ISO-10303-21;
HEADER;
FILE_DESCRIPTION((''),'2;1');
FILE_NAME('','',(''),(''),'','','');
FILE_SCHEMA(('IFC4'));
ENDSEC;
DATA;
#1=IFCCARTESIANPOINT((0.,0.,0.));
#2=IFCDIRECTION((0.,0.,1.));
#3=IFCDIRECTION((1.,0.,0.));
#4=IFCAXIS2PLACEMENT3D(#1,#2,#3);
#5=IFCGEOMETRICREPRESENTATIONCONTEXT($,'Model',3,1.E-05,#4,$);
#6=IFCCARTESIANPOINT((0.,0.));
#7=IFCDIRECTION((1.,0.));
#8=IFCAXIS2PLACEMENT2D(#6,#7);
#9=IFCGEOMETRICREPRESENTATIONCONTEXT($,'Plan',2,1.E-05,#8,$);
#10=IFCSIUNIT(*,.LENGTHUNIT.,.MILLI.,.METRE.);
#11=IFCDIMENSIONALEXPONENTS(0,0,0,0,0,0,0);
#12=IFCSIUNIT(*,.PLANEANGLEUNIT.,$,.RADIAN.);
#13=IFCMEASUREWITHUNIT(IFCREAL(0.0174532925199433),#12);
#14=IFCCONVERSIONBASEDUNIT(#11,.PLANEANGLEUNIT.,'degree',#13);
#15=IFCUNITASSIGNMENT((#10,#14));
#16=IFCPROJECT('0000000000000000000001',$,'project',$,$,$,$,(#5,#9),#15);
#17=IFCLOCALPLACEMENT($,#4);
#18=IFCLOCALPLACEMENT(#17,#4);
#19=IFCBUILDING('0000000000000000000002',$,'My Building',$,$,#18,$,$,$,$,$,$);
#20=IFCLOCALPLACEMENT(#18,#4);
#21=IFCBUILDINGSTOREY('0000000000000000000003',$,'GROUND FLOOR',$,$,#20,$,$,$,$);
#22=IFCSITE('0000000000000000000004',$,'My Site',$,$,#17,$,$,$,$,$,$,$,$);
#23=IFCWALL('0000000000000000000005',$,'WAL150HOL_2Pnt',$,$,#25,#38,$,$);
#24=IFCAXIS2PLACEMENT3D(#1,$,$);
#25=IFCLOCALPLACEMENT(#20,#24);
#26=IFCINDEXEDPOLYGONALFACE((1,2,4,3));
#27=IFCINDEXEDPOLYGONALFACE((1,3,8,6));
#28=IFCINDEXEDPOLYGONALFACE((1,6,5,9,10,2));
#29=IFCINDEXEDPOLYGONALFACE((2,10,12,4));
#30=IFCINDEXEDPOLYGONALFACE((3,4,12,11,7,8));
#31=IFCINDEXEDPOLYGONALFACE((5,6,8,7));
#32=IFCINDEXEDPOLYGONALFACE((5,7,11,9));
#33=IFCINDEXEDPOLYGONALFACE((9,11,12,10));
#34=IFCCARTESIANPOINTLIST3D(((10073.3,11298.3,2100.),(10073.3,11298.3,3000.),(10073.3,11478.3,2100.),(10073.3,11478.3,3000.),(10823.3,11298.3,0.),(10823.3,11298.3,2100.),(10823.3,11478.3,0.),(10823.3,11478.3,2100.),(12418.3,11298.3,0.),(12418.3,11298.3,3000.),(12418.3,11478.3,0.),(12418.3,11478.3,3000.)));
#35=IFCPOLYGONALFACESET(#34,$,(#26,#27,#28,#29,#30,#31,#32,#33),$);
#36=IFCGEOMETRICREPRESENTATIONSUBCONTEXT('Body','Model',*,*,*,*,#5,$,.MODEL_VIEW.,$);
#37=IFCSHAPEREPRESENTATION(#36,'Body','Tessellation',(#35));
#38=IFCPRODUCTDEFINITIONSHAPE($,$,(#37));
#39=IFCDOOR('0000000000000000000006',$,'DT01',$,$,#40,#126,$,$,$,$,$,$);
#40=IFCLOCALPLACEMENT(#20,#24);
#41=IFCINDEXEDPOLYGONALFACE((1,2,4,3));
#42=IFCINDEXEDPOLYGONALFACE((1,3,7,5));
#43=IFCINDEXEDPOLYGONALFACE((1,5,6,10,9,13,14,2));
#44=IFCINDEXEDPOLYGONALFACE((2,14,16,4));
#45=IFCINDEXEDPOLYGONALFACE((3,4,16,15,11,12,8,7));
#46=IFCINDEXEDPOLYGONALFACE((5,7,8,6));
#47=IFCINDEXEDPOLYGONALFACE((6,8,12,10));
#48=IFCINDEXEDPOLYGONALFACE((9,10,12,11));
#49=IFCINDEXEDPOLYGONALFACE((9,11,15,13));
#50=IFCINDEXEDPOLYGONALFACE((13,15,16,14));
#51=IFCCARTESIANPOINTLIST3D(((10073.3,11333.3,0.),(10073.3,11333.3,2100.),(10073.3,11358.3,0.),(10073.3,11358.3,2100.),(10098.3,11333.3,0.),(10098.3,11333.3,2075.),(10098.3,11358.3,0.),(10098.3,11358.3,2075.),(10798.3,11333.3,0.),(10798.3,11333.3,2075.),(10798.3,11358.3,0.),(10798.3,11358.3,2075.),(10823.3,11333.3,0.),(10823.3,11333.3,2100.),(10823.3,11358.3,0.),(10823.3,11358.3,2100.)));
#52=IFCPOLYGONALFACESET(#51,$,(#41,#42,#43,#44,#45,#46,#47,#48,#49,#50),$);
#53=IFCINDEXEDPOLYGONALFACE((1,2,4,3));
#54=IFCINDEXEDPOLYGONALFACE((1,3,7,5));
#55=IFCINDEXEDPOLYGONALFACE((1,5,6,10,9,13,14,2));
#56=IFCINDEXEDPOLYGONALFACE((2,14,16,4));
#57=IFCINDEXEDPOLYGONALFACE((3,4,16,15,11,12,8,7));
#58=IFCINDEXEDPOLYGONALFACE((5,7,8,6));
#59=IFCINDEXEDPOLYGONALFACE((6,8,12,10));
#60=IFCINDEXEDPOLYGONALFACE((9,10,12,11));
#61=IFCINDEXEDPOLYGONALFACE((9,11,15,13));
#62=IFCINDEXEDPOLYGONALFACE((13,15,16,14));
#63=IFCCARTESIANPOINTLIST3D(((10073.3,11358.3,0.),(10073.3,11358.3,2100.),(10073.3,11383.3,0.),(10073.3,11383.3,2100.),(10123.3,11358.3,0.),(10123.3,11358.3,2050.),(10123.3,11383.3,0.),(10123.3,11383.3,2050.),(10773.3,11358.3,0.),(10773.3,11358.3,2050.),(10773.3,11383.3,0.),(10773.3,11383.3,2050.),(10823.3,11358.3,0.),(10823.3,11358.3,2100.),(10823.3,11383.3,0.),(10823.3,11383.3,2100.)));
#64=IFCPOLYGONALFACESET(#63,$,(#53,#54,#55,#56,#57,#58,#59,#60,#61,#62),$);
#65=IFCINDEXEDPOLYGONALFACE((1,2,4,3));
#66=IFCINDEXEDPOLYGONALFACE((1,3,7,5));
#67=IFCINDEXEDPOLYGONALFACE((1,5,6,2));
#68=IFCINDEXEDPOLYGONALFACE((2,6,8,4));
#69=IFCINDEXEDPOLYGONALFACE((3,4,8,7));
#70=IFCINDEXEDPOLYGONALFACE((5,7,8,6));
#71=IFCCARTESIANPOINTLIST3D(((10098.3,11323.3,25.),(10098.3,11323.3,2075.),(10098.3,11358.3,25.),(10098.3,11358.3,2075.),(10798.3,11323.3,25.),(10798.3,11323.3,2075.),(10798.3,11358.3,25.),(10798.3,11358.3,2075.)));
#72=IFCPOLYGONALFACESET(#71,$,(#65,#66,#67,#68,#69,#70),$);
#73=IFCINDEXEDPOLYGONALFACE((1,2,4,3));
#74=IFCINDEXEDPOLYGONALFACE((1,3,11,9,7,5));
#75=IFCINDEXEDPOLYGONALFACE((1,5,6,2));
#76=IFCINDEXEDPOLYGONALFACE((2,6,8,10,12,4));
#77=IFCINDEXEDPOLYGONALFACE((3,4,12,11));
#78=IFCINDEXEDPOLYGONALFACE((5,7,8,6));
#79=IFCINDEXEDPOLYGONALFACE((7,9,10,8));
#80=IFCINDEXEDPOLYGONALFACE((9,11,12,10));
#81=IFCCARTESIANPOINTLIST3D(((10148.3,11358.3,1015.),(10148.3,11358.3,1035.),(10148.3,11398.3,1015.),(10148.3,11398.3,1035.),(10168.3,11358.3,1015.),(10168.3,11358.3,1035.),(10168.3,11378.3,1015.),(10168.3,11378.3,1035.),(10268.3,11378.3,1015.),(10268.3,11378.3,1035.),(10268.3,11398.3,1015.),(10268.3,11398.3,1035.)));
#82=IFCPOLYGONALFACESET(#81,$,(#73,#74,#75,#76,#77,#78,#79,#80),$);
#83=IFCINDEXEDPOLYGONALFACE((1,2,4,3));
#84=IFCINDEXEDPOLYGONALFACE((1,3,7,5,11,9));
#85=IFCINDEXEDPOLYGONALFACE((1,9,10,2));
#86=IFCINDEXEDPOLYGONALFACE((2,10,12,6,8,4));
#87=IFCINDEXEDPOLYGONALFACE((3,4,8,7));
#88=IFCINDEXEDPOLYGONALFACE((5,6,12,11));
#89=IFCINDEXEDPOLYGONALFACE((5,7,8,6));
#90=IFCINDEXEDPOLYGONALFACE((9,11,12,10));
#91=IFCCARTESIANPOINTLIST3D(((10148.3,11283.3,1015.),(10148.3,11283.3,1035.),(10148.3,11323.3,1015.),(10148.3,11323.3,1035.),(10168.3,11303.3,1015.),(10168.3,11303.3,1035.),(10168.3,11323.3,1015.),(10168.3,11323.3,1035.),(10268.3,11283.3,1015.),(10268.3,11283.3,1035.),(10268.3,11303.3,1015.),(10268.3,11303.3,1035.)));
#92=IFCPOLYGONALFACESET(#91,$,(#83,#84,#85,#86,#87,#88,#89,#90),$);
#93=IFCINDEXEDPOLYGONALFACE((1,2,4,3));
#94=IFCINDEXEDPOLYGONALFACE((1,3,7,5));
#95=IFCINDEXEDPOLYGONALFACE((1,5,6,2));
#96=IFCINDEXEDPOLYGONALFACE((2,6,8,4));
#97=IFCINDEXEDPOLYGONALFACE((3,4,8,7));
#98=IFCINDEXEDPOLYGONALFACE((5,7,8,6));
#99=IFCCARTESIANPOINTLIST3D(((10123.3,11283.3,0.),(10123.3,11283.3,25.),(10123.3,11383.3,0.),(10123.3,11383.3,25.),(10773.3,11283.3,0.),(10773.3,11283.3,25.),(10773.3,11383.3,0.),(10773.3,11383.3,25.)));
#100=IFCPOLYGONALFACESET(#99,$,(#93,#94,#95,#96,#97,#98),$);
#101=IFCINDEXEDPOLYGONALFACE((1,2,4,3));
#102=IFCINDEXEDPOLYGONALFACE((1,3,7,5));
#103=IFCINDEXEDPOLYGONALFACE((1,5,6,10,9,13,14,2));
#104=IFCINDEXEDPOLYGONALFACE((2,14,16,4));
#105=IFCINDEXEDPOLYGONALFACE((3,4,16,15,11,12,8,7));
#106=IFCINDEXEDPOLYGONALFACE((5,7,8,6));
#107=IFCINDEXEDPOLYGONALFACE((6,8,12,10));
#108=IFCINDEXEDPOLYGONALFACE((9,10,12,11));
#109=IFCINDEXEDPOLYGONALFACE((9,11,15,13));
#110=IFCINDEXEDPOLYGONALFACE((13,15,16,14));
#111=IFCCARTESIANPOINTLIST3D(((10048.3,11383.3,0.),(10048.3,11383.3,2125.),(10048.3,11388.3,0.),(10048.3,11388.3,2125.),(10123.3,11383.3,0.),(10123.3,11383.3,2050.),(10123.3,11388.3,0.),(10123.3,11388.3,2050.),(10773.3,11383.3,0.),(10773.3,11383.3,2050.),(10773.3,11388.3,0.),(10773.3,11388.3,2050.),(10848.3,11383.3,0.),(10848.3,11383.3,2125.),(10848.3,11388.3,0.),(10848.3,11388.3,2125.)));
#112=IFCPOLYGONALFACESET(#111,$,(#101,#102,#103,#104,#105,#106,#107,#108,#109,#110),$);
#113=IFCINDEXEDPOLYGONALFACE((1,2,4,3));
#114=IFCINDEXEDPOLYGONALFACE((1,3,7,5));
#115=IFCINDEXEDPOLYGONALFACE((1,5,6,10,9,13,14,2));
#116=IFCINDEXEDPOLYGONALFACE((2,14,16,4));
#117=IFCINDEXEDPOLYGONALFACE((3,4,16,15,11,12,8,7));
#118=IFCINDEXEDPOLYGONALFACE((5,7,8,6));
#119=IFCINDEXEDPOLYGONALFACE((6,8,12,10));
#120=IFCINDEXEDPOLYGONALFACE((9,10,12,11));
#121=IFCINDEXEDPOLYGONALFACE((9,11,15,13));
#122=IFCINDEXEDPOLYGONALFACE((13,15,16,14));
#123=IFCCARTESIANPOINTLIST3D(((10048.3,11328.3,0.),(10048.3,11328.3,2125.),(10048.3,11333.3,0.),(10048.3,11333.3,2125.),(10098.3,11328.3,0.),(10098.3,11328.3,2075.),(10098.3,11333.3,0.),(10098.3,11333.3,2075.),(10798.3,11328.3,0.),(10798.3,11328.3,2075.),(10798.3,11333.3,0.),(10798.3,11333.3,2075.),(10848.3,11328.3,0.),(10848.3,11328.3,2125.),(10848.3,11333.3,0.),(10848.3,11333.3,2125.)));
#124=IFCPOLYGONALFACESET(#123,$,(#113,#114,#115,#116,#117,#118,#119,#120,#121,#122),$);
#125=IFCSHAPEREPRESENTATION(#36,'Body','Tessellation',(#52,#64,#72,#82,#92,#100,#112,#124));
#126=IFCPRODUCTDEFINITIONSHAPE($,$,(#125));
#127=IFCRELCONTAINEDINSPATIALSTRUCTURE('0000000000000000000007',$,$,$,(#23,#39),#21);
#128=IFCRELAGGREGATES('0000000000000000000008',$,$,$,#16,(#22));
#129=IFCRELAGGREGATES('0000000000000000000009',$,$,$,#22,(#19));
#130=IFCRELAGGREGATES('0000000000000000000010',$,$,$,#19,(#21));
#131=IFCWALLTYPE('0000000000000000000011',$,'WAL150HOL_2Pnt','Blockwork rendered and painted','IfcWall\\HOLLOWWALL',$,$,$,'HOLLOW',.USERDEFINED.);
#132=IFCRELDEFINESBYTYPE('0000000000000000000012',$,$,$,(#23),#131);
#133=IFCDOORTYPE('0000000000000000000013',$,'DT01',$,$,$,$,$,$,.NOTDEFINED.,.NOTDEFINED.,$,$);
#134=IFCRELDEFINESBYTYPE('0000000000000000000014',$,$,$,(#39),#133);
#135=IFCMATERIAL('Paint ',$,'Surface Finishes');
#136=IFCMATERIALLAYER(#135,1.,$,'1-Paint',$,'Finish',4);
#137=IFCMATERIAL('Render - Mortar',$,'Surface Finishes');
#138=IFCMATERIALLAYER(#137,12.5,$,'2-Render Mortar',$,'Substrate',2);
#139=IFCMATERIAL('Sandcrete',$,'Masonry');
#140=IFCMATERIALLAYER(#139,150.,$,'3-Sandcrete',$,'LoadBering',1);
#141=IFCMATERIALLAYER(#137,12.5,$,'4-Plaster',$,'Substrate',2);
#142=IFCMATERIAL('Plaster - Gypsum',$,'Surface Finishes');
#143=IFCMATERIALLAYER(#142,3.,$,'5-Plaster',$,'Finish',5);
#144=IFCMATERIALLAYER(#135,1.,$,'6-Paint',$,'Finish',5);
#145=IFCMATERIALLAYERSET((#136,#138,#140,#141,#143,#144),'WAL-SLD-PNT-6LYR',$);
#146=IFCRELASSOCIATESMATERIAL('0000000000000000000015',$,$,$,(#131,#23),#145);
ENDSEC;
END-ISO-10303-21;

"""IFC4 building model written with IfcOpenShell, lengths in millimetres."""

from ifc_helpers import new_model, entity, si_unit, converted_unit, frame, origin_with_axes, origin_2d_with_axis, place, context, subcontext, project, spatial, line, indexed_curve, outline, extrude, shape, source, transform, mapped, material, layer, layer_set, layer_usage, type_object, type_shapes, element, fill, save


model = new_model("IFC4")

# Units and contexts
model_context = context("Model", 3, precision=1e-05, world=origin_with_axes())
plan_context = context("Plan", 2, precision=1e-05, world=origin_2d_with_axis())
body_context_1 = subcontext(model_context, "Body", "Model", "MODEL_VIEW")
body_context_2 = subcontext(plan_context, "Body", "Plan", "PLAN_VIEW")
ifc_project = project(units=[si_unit("LENGTHUNIT", "METRE", prefix="MILLI"), converted_unit("PLANEANGLEUNIT", "degree", entity("IfcReal", 0.0174532925199433), si_unit("PLANEANGLEUNIT", "RADIAN"), dimensions=[0, 0, 0, 0, 0, 0, 0])], contexts=[model_context, plan_context])

# Site, building, storey
site_placement = place(None, origin_with_axes())
site = spatial("IfcSite", under=ifc_project, at=site_placement, Name="My Site")
building_placement = place(site_placement, origin_with_axes())
building = spatial("IfcBuilding", under=site, at=building_placement, Name="My Building")
storey_placement = place(building_placement, origin_with_axes())
storey = spatial("IfcBuildingStorey", under=building, at=storey_placement, Name="GROUND FLOOR")

# Shared definitions
ifc_material_1 = material(Name="Paint ", Category="Surface Finishes")
ifc_layer_1 = layer(ifc_material_1, 1.0, Name="1-Paint", Category="Finish", Priority=4)
ifc_material_2 = material(Name="Render - Mortar", Category="Surface Finishes")
ifc_layer_2 = layer(ifc_material_2, 12.5, Name="2-Render Mortar", Category="Substrate", Priority=2)
ifc_material_3 = material(Name="Sandcrete", Category="Masonry")
ifc_layer_3 = layer(ifc_material_3, 150.0, Name="3-Sandcrete", Category="LoadBering", Priority=1)
ifc_layer_4 = layer(ifc_material_2, 12.5, Name="4-Plaster", Category="Substrate", Priority=2)
ifc_material_4 = material(Name="Plaster - Gypsum", Category="Surface Finishes")
ifc_layer_5 = layer(ifc_material_4, 3.0, Name="5-Plaster", Category="Finish", Priority=5)
ifc_layer_6 = layer(ifc_material_1, 1.0, Name="6-Paint", Category="Finish", Priority=5)
ifc_layer_set_1 = layer_set([ifc_layer_1, ifc_layer_2, ifc_layer_3, ifc_layer_4, ifc_layer_5, ifc_layer_6], Name="WAL-SLD-PNT-6LYR")
wall_type_1 = type_object("IfcWallType", Name="WAL150HOL_2Pnt", Description="Blockwork rendered and painted", ApplicableOccurrence="IfcWall\\HOLLOWWALL", ElementType="HOLLOW", PredefinedType="USERDEFINED", material=ifc_layer_set_1)

# Shared definitions
shared_shape_1 = source(origin_with_axes(), body_context_1, "Body", "SweptSolid", [
    extrude(outline(indexed_curve([(0.0, 0.0), (750.0, 0.0), (750.0, 2100.0), (0.0, 2100.0)], segments=[line(1, 2, 3, 4, 1)])), frame((0.0, -100.0, 0.0), z_axis=(0.0, -1.0, 0.0), x_axis=(1.0, 0.0, 0.0)), (0.0, 0.0, -1.0), 380.0),
])
door_type_1 = type_object("IfcDoorType", Name="DT01", OperationType="NOTDEFINED", PredefinedType="NOTDEFINED")
shared_shape_2 = source(origin_with_axes(), body_context_1, "Body", "SweptSolid", [
    extrude(outline(indexed_curve([(0.0, 0.0), (0.0, 2100.0), (750.0, 2100.0), (750.0, 0.0), (725.0, 0.0), (725.0, 2075.0), (25.0, 2075.0), (25.0, 0.0)], segments=[line(1, 2, 3, 4, 5, 6, 7, 8, 1)])), frame((0.0, 25.0, 0.0), z_axis=(0.0, -1.0, 0.0), x_axis=(1.0, 0.0, 0.0)), (0.0, 0.0, -1.0), 25.0),
    extrude(outline(indexed_curve([(0.0, 0.0), (0.0, 2100.0), (750.0, 2100.0), (750.0, 0.0), (700.0, 0.0), (700.0, 2050.0), (50.0, 2050.0), (50.0, 0.0)], segments=[line(1, 2, 3, 4, 5, 6, 7, 8, 1)])), frame((0.0, 0.0, 0.0), z_axis=(0.0, -1.0, 0.0), x_axis=(1.0, 0.0, 0.0)), (0.0, 0.0, -1.0), 25.0),
    extrude(outline(indexed_curve([(0.0, 0.0), (700.0, 0.0), (700.0, 35.0), (0.0, 35.0)], segments=[line(1, 2, 3, 4, 1)])), frame((25.0, 25.0, 25.0), z_axis=(0.0, 0.0, 1.0), x_axis=(1.0, 0.0, 0.0)), (0.0, 0.0, 1.0), 2050.0),
    extrude(outline(indexed_curve([(0.0, 0.0), (0.0, -40.0), (-120.0, -40.0), (-120.0, -20.0), (-20.0, -20.0), (-20.0, 0.0)], segments=[line(1, 2, 3, 4, 5, 6, 1)])), frame((675.0, 25.0, 1015.0), z_axis=(0.0, 0.0, 1.0), x_axis=(1.0, 0.0, 0.0)), (0.0, 0.0, 1.0), 20.0),
    extrude(outline(indexed_curve([(0.0, 0.0), (0.0, 40.0), (-120.0, 40.0), (-120.0, 20.0), (-20.0, 20.0), (-20.0, 0.0)], segments=[line(1, 2, 3, 4, 5, 6, 1)])), frame((675.0, 60.0, 1015.0), z_axis=(0.0, 0.0, 1.0), x_axis=(1.0, 0.0, 0.0)), (0.0, 0.0, 1.0), 20.0),
    extrude(outline(indexed_curve([(0.0, 0.0), (650.0, 0.0), (650.0, 100.0), (0.0, 100.0)], segments=[line(1, 2, 3, 4, 1)])), frame((50.0, 0.0, 0.0), z_axis=(0.0, 0.0, 1.0), x_axis=(1.0, 0.0, 0.0)), (0.0, 0.0, 1.0), 25.0),
    extrude(outline(indexed_curve([(0.0, 0.0), (0.0, 2125.0), (800.0, 2125.0), (800.0, 0.0), (725.0, 0.0), (725.0, 2050.0), (75.0, 2050.0), (75.0, 0.0)], segments=[line(1, 2, 3, 4, 5, 6, 7, 8, 1)])), frame((-25.0, -5.0, 0.0), z_axis=(0.0, -1.0, 0.0), x_axis=(1.0, 0.0, 0.0)), (0.0, 0.0, -1.0), 5.0),
    extrude(outline(indexed_curve([(0.0, 0.0), (0.0, 2125.0), (800.0, 2125.0), (800.0, 0.0), (750.0, 0.0), (750.0, 2075.0), (50.0, 2075.0), (50.0, 0.0)], segments=[line(1, 2, 3, 4, 5, 6, 7, 8, 1)])), frame((-25.0, 50.0, 0.0), z_axis=(0.0, -1.0, 0.0), x_axis=(1.0, 0.0, 0.0)), (0.0, 0.0, -1.0), 5.0),
])
shared_shape_3 = source(origin_with_axes(), body_context_2, "Body", "Curve2D", [
    entity("IfcIndexedPolyCurve", entity("IfcCartesianPointList2D", [[0.0, 0.0], [0.0, 50.0], [25.0, 50.0], [25.0, 25.0], [50.0, 25.0], [50.0, 0.0]]), [entity("IfcLineIndex", [1, 2, 3, 4, 5, 6, 1])]),
    entity("IfcIndexedPolyCurve", entity("IfcCartesianPointList2D", [[750.0, 0.0], [750.0, 50.0], [725.0, 50.0], [725.0, 25.0], [700.0, 25.0], [700.0, 0.0]]), [entity("IfcLineIndex", [1, 2, 3, 4, 5, 6, 1])]),
    entity("IfcTrimmedCurve", entity("IfcEllipse", entity("IfcAxis2Placement2D", entity("IfcCartesianPoint", [60.0, 50.0]), entity("IfcDirection", [1.0, 0.0])), 665.0, 700.0), [entity("IfcCartesianPoint", [725.0, 50.0])], [entity("IfcCartesianPoint", [60.0, 750.0])], True, "CARTESIAN"),
    entity("IfcIndexedPolyCurve", entity("IfcCartesianPointList2D", [[25.0, 50.0], [60.0, 50.0], [60.0, 750.0], [25.0, 750.0]]), [entity("IfcLineIndex", [1, 2, 3, 4, 1])]),
])
type_shapes(door_type_1, [shared_shape_2, shared_shape_3])

# Wall, opening, door
ifc_layer_usage_1 = layer_usage(ifc_layer_set_1, "AXIS2", "POSITIVE", 0.0)
wall_1_placement = place(storey_placement, frame((10073.3, 11298.3, 0.0), z_axis=(0.0, 0.0, 1.0), x_axis=(1.0, -0.000001, 0.0)))
wall_1 = element("IfcWall", 1, at=wall_1_placement, inside=storey, type_object=wall_type_1, material=ifc_layer_usage_1, Name="WAL150HOL_2Pnt", context=body_context_1, shape_type="SweptSolid", body=[
    extrude(outline(indexed_curve([(0.0, 0.0), (0.0, 180.0), (2345.0, 180.0), (2345.0, 0.0), (0.0, 0.0)], self_intersect=False)), origin_with_axes(), (0.0, 0.0, 1.0), 3000.0),
])
opening_1_placement = place(wall_1_placement, frame((0.0, 0.0, 0.0), z_axis=(0.0, 0.0, 1.0), x_axis=(1.0, 0.0, 0.0)))
opening_1 = element("IfcOpeningElement", 2, at=opening_1_placement, cuts=wall_1, PredefinedType="OPENING", context=body_context_1, shape_type="MappedRepresentation", body=[
    mapped(shared_shape_1, transform((0.0, 0.0, 0.0), x_axis=(1.0, 0.0, 0.0), y_axis=(0.0, 1.0, 0.0), z_axis=(0.0, 0.0, 1.0), scale=1.0)),
])
door_1_placement = place(opening_1_placement, frame((750.0, 85.0, 0.0), z_axis=(0.0, 0.0, 1.0), x_axis=(-1.0, 0.0, 0.0)))
door_1 = element("IfcDoor", 3, at=door_1_placement, inside=storey, type_object=door_type_1, Name="DT01", shapes=[
    shape(body_context_1, "Body", "MappedRepresentation", [mapped(shared_shape_2, transform((0.0, 0.0, 0.0), x_axis=(1.0, 0.0, 0.0), y_axis=(0.0, 1.0, 0.0), z_axis=(0.0, 0.0, 1.0), scale=1.0))]),
    shape(body_context_2, "Body", "MappedRepresentation", [mapped(shared_shape_3, transform((0.0, 0.0, 0.0), x_axis=(1.0, 0.0, 0.0), y_axis=(0.0, 1.0, 0.0), z_axis=(0.0, 0.0, 1.0), scale=1.0))]),
])
fill(opening_1, door_1)

save(model, "model.ifc")
